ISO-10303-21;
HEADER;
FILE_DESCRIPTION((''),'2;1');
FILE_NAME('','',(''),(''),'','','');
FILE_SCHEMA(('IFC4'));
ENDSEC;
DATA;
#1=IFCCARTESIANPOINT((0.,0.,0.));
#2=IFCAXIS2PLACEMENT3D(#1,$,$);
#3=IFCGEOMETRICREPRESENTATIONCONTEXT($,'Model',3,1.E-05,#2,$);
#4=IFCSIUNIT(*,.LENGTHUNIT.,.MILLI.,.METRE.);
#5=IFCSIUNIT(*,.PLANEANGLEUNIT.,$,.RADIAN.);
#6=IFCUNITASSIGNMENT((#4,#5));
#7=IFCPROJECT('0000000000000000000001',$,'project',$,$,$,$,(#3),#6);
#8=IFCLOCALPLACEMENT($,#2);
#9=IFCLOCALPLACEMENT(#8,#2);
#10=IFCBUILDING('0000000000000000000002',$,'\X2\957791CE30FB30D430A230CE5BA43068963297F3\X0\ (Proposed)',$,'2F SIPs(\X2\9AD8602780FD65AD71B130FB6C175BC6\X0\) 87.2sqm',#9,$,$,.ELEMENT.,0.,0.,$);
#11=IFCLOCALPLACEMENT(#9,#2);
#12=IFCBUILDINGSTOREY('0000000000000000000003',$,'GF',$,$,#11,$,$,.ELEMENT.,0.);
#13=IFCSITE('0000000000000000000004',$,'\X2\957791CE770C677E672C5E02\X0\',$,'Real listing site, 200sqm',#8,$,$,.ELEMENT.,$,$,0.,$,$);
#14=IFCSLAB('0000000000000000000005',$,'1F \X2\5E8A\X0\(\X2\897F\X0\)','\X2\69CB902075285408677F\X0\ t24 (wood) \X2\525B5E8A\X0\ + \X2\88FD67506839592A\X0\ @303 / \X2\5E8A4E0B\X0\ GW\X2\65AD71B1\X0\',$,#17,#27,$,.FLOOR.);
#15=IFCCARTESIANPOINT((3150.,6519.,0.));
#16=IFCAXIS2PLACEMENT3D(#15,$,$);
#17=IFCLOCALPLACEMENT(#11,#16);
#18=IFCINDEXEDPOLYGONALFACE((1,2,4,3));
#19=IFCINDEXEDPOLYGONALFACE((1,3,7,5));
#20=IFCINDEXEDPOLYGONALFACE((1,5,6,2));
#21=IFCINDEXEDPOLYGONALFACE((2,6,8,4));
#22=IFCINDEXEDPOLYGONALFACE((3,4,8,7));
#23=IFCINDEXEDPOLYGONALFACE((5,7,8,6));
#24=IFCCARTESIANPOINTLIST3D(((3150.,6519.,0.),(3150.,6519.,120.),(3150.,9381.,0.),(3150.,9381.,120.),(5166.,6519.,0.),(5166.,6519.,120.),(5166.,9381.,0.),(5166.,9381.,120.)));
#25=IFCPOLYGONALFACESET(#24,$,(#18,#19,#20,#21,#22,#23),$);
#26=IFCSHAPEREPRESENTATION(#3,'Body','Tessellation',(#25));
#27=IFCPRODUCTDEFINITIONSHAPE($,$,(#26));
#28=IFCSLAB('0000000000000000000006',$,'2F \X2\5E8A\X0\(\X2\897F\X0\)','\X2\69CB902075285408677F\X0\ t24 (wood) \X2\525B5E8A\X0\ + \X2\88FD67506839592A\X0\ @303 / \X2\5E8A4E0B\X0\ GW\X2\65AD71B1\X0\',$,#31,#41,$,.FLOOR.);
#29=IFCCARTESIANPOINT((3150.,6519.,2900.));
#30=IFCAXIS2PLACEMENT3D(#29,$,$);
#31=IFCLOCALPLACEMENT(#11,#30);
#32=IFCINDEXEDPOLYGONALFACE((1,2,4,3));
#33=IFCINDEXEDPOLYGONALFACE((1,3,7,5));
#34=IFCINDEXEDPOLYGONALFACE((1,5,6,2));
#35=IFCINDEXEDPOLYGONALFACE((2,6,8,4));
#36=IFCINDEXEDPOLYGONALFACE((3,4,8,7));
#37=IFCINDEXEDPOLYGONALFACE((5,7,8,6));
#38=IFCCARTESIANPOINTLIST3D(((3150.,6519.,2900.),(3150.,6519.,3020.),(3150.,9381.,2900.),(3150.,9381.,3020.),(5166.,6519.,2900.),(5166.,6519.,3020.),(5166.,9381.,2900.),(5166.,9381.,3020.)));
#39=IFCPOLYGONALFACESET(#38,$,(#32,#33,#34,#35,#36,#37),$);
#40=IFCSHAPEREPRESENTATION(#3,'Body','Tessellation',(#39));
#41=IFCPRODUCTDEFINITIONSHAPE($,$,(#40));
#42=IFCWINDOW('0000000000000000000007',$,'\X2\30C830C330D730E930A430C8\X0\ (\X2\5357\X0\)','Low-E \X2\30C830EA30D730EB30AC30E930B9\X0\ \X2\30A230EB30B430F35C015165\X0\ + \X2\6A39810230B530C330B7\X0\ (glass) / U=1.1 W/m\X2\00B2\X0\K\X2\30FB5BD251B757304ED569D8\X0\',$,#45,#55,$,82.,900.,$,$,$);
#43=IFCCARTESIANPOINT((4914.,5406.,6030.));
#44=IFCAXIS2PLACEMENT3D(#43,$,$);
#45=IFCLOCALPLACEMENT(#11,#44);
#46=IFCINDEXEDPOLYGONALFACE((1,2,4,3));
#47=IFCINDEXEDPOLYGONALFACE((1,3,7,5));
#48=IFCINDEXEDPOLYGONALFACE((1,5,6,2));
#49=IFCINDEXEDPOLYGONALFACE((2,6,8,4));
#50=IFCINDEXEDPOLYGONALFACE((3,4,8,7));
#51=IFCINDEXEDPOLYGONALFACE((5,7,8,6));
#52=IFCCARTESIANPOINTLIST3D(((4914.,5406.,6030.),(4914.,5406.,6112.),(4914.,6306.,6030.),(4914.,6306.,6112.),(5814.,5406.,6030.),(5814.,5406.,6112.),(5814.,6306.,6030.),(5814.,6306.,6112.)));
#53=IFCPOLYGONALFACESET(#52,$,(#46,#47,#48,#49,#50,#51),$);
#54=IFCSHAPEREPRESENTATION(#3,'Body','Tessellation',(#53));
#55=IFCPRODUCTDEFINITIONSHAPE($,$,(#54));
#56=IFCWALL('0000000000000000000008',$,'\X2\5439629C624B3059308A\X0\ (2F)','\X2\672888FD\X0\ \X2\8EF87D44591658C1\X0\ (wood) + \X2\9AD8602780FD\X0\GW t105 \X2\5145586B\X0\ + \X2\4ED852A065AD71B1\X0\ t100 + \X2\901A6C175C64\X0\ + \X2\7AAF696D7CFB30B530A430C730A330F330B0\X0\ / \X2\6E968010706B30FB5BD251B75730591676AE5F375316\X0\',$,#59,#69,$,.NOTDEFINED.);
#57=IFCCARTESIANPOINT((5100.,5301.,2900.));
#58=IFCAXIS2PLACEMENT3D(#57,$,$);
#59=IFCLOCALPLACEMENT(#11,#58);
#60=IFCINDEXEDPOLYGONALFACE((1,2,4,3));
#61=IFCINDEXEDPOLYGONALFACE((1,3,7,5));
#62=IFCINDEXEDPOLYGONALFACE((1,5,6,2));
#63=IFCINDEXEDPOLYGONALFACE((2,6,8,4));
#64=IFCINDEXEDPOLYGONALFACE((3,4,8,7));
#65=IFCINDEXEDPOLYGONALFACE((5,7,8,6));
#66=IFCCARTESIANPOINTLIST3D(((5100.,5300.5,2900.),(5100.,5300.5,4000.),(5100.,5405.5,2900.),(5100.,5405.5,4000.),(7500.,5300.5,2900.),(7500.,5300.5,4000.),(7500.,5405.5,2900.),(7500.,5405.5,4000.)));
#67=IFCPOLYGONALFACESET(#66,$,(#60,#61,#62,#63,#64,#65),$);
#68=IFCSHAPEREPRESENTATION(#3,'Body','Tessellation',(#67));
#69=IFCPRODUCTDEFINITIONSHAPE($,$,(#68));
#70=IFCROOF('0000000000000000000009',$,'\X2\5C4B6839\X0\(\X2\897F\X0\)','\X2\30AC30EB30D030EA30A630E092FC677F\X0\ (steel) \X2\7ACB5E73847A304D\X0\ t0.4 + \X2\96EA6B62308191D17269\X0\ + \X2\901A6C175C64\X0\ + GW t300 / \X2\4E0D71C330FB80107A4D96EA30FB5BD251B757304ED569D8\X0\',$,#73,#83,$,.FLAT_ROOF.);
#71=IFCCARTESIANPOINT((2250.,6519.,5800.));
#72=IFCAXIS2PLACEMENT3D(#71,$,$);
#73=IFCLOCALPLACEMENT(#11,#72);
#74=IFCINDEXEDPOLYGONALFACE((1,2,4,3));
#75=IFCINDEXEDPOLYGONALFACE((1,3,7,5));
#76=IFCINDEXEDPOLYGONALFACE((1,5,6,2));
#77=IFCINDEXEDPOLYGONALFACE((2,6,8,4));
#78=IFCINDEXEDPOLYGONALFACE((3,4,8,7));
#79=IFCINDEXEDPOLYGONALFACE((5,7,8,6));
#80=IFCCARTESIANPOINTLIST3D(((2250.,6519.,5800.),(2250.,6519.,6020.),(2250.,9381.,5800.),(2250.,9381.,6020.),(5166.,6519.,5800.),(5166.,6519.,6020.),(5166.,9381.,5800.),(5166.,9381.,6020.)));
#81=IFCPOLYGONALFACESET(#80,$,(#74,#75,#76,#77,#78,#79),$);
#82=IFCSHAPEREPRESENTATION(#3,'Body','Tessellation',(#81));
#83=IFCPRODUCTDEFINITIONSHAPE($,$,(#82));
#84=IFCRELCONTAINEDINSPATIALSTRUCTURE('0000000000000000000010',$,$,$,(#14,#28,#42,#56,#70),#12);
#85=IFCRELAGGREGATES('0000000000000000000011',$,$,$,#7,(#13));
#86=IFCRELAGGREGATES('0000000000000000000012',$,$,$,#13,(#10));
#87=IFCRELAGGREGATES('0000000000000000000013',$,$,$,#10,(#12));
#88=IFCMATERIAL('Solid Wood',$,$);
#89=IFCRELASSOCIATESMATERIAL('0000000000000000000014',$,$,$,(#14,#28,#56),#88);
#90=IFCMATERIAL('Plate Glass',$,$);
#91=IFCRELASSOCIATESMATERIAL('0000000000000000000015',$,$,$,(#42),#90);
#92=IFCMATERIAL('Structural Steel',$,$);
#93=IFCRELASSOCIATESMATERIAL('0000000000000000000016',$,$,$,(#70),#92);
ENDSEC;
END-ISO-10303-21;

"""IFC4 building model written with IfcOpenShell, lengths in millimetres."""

from ifc_helpers import new_model, si_unit, frame, frame_2d, origin, place, context, project, spatial, rectangle, extrude, material, element, save


model = new_model("IFC4")

# Units and contexts
model_context = context("Model", 3, precision=1e-05, world=origin())
ifc_project = project(units=[si_unit("LENGTHUNIT", "METRE", prefix="MILLI"), si_unit("PLANEANGLEUNIT", "RADIAN")], contexts=[model_context])

# Site, building, storey
site_placement = place(None, origin())
site = spatial("IfcSite", under=ifc_project, at=site_placement, Name="長野県松本市", ObjectType="Real listing site, 200sqm", CompositionType="ELEMENT", RefElevation=0.0)
building_placement = place(site_placement, origin())
building = spatial("IfcBuilding", under=site, at=building_placement, Name="長野・ピアノ室と防音 (Proposed)", ObjectType="2F SIPs(高性能断熱・気密) 87.2sqm", CompositionType="ELEMENT", ElevationOfRefHeight=0.0, ElevationOfTerrain=0.0)
storey_placement = place(building_placement, origin())
storey = spatial("IfcBuildingStorey", under=building, at=storey_placement, Name="GF", CompositionType="ELEMENT", Elevation=0.0)

# Shared definitions
ifc_material_1 = material(Name="Solid Wood")

# Slabs
slab_1_placement = place(storey_placement, frame((3150.0, 6519.0, 0.0)))
element("IfcSlab", 1, at=slab_1_placement, inside=storey, material=ifc_material_1, Name="1F 床(西)", Description="構造用合板 t24 (wood) 剛床 + 製材根太 @303 / 床下 GW断熱", PredefinedType="FLOOR", context=model_context, shape_type="SweptSolid", body=[
    extrude(rectangle(XDim=2016.0, YDim=2862.0, at=frame_2d((1008.0, 1431.0))), frame((3150.0, 6519.0, 0.0)), (0.0, 0.0, 1.0), 120.0),
])
slab_2_placement = place(storey_placement, frame((3150.0, 6519.0, 2900.0)))
element("IfcSlab", 2, at=slab_2_placement, inside=storey, material=ifc_material_1, Name="2F 床(西)", Description="構造用合板 t24 (wood) 剛床 + 製材根太 @303 / 床下 GW断熱", PredefinedType="FLOOR", context=model_context, shape_type="SweptSolid", body=[
    extrude(rectangle(XDim=2016.0, YDim=2862.0, at=frame_2d((1008.0, 1431.0))), frame((3150.0, 6519.0, 2900.0)), (0.0, 0.0, 1.0), 120.0),
])

# Window
ifc_material_2 = material(Name="Plate Glass")
window_placement = place(storey_placement, frame((4914.0, 5406.0, 6030.0)))
element("IfcWindow", 3, at=window_placement, inside=storey, material=ifc_material_2, Name="トップライト (南)", Description="Low-E トリプルガラス アルゴン封入 + 樹脂サッシ (glass) / U=1.1 W/m²K・寒冷地仕様", OverallHeight=82.0, OverallWidth=900.0, context=model_context, shape_type="SweptSolid", body=[
    extrude(rectangle(XDim=900.0, YDim=900.0, at=frame_2d((450.0, 450.0))), frame((4914.0, 5406.0, 6030.0)), (0.0, 0.0, 1.0), 82.0),
])

# Wall
wall_placement = place(storey_placement, frame((5100.0, 5301.0, 2900.0)))
element("IfcWall", 4, at=wall_placement, inside=storey, material=ifc_material_1, Name="吹抜手すり (2F)", Description="木製 軸組外壁 (wood) + 高性能GW t105 充填 + 付加断熱 t100 + 通気層 + 窯業系サイディング / 準耐火・寒冷地外皮強化", PredefinedType="NOTDEFINED", context=model_context, shape_type="SweptSolid", body=[
    extrude(rectangle(XDim=2400.0, YDim=105.0, at=frame_2d((1200.0, 52.0))), frame((5100.0, 5301.0, 2900.0)), (0.0, 0.0, 1.0), 1100.0),
])

# Roof
ifc_material_3 = material(Name="Structural Steel")
for number, where, name in (
    (5, (2250.0, 6519.0, 5800.0), "屋根(西)"),
):
    element("IfcRoof", number, at=place(storey_placement, frame(where)), inside=storey, material=ifc_material_3, Name=name, Description="ガルバリウム鋼板 (steel) 立平葺き t0.4 + 雪止め金物 + 通気層 + GW t300 / 不燃・耐積雪・寒冷地仕様", PredefinedType="FLAT_ROOF", context=model_context, shape_type="SweptSolid", body=[
        extrude(rectangle(XDim=2916.0, YDim=2862.0, at=frame_2d((1458.0, 1431.0))), frame((2250.0, 6519.0, 5800.0)), (0.0, 0.0, 1.0), 220.0),
    ])

save(model, "model.ifc")
